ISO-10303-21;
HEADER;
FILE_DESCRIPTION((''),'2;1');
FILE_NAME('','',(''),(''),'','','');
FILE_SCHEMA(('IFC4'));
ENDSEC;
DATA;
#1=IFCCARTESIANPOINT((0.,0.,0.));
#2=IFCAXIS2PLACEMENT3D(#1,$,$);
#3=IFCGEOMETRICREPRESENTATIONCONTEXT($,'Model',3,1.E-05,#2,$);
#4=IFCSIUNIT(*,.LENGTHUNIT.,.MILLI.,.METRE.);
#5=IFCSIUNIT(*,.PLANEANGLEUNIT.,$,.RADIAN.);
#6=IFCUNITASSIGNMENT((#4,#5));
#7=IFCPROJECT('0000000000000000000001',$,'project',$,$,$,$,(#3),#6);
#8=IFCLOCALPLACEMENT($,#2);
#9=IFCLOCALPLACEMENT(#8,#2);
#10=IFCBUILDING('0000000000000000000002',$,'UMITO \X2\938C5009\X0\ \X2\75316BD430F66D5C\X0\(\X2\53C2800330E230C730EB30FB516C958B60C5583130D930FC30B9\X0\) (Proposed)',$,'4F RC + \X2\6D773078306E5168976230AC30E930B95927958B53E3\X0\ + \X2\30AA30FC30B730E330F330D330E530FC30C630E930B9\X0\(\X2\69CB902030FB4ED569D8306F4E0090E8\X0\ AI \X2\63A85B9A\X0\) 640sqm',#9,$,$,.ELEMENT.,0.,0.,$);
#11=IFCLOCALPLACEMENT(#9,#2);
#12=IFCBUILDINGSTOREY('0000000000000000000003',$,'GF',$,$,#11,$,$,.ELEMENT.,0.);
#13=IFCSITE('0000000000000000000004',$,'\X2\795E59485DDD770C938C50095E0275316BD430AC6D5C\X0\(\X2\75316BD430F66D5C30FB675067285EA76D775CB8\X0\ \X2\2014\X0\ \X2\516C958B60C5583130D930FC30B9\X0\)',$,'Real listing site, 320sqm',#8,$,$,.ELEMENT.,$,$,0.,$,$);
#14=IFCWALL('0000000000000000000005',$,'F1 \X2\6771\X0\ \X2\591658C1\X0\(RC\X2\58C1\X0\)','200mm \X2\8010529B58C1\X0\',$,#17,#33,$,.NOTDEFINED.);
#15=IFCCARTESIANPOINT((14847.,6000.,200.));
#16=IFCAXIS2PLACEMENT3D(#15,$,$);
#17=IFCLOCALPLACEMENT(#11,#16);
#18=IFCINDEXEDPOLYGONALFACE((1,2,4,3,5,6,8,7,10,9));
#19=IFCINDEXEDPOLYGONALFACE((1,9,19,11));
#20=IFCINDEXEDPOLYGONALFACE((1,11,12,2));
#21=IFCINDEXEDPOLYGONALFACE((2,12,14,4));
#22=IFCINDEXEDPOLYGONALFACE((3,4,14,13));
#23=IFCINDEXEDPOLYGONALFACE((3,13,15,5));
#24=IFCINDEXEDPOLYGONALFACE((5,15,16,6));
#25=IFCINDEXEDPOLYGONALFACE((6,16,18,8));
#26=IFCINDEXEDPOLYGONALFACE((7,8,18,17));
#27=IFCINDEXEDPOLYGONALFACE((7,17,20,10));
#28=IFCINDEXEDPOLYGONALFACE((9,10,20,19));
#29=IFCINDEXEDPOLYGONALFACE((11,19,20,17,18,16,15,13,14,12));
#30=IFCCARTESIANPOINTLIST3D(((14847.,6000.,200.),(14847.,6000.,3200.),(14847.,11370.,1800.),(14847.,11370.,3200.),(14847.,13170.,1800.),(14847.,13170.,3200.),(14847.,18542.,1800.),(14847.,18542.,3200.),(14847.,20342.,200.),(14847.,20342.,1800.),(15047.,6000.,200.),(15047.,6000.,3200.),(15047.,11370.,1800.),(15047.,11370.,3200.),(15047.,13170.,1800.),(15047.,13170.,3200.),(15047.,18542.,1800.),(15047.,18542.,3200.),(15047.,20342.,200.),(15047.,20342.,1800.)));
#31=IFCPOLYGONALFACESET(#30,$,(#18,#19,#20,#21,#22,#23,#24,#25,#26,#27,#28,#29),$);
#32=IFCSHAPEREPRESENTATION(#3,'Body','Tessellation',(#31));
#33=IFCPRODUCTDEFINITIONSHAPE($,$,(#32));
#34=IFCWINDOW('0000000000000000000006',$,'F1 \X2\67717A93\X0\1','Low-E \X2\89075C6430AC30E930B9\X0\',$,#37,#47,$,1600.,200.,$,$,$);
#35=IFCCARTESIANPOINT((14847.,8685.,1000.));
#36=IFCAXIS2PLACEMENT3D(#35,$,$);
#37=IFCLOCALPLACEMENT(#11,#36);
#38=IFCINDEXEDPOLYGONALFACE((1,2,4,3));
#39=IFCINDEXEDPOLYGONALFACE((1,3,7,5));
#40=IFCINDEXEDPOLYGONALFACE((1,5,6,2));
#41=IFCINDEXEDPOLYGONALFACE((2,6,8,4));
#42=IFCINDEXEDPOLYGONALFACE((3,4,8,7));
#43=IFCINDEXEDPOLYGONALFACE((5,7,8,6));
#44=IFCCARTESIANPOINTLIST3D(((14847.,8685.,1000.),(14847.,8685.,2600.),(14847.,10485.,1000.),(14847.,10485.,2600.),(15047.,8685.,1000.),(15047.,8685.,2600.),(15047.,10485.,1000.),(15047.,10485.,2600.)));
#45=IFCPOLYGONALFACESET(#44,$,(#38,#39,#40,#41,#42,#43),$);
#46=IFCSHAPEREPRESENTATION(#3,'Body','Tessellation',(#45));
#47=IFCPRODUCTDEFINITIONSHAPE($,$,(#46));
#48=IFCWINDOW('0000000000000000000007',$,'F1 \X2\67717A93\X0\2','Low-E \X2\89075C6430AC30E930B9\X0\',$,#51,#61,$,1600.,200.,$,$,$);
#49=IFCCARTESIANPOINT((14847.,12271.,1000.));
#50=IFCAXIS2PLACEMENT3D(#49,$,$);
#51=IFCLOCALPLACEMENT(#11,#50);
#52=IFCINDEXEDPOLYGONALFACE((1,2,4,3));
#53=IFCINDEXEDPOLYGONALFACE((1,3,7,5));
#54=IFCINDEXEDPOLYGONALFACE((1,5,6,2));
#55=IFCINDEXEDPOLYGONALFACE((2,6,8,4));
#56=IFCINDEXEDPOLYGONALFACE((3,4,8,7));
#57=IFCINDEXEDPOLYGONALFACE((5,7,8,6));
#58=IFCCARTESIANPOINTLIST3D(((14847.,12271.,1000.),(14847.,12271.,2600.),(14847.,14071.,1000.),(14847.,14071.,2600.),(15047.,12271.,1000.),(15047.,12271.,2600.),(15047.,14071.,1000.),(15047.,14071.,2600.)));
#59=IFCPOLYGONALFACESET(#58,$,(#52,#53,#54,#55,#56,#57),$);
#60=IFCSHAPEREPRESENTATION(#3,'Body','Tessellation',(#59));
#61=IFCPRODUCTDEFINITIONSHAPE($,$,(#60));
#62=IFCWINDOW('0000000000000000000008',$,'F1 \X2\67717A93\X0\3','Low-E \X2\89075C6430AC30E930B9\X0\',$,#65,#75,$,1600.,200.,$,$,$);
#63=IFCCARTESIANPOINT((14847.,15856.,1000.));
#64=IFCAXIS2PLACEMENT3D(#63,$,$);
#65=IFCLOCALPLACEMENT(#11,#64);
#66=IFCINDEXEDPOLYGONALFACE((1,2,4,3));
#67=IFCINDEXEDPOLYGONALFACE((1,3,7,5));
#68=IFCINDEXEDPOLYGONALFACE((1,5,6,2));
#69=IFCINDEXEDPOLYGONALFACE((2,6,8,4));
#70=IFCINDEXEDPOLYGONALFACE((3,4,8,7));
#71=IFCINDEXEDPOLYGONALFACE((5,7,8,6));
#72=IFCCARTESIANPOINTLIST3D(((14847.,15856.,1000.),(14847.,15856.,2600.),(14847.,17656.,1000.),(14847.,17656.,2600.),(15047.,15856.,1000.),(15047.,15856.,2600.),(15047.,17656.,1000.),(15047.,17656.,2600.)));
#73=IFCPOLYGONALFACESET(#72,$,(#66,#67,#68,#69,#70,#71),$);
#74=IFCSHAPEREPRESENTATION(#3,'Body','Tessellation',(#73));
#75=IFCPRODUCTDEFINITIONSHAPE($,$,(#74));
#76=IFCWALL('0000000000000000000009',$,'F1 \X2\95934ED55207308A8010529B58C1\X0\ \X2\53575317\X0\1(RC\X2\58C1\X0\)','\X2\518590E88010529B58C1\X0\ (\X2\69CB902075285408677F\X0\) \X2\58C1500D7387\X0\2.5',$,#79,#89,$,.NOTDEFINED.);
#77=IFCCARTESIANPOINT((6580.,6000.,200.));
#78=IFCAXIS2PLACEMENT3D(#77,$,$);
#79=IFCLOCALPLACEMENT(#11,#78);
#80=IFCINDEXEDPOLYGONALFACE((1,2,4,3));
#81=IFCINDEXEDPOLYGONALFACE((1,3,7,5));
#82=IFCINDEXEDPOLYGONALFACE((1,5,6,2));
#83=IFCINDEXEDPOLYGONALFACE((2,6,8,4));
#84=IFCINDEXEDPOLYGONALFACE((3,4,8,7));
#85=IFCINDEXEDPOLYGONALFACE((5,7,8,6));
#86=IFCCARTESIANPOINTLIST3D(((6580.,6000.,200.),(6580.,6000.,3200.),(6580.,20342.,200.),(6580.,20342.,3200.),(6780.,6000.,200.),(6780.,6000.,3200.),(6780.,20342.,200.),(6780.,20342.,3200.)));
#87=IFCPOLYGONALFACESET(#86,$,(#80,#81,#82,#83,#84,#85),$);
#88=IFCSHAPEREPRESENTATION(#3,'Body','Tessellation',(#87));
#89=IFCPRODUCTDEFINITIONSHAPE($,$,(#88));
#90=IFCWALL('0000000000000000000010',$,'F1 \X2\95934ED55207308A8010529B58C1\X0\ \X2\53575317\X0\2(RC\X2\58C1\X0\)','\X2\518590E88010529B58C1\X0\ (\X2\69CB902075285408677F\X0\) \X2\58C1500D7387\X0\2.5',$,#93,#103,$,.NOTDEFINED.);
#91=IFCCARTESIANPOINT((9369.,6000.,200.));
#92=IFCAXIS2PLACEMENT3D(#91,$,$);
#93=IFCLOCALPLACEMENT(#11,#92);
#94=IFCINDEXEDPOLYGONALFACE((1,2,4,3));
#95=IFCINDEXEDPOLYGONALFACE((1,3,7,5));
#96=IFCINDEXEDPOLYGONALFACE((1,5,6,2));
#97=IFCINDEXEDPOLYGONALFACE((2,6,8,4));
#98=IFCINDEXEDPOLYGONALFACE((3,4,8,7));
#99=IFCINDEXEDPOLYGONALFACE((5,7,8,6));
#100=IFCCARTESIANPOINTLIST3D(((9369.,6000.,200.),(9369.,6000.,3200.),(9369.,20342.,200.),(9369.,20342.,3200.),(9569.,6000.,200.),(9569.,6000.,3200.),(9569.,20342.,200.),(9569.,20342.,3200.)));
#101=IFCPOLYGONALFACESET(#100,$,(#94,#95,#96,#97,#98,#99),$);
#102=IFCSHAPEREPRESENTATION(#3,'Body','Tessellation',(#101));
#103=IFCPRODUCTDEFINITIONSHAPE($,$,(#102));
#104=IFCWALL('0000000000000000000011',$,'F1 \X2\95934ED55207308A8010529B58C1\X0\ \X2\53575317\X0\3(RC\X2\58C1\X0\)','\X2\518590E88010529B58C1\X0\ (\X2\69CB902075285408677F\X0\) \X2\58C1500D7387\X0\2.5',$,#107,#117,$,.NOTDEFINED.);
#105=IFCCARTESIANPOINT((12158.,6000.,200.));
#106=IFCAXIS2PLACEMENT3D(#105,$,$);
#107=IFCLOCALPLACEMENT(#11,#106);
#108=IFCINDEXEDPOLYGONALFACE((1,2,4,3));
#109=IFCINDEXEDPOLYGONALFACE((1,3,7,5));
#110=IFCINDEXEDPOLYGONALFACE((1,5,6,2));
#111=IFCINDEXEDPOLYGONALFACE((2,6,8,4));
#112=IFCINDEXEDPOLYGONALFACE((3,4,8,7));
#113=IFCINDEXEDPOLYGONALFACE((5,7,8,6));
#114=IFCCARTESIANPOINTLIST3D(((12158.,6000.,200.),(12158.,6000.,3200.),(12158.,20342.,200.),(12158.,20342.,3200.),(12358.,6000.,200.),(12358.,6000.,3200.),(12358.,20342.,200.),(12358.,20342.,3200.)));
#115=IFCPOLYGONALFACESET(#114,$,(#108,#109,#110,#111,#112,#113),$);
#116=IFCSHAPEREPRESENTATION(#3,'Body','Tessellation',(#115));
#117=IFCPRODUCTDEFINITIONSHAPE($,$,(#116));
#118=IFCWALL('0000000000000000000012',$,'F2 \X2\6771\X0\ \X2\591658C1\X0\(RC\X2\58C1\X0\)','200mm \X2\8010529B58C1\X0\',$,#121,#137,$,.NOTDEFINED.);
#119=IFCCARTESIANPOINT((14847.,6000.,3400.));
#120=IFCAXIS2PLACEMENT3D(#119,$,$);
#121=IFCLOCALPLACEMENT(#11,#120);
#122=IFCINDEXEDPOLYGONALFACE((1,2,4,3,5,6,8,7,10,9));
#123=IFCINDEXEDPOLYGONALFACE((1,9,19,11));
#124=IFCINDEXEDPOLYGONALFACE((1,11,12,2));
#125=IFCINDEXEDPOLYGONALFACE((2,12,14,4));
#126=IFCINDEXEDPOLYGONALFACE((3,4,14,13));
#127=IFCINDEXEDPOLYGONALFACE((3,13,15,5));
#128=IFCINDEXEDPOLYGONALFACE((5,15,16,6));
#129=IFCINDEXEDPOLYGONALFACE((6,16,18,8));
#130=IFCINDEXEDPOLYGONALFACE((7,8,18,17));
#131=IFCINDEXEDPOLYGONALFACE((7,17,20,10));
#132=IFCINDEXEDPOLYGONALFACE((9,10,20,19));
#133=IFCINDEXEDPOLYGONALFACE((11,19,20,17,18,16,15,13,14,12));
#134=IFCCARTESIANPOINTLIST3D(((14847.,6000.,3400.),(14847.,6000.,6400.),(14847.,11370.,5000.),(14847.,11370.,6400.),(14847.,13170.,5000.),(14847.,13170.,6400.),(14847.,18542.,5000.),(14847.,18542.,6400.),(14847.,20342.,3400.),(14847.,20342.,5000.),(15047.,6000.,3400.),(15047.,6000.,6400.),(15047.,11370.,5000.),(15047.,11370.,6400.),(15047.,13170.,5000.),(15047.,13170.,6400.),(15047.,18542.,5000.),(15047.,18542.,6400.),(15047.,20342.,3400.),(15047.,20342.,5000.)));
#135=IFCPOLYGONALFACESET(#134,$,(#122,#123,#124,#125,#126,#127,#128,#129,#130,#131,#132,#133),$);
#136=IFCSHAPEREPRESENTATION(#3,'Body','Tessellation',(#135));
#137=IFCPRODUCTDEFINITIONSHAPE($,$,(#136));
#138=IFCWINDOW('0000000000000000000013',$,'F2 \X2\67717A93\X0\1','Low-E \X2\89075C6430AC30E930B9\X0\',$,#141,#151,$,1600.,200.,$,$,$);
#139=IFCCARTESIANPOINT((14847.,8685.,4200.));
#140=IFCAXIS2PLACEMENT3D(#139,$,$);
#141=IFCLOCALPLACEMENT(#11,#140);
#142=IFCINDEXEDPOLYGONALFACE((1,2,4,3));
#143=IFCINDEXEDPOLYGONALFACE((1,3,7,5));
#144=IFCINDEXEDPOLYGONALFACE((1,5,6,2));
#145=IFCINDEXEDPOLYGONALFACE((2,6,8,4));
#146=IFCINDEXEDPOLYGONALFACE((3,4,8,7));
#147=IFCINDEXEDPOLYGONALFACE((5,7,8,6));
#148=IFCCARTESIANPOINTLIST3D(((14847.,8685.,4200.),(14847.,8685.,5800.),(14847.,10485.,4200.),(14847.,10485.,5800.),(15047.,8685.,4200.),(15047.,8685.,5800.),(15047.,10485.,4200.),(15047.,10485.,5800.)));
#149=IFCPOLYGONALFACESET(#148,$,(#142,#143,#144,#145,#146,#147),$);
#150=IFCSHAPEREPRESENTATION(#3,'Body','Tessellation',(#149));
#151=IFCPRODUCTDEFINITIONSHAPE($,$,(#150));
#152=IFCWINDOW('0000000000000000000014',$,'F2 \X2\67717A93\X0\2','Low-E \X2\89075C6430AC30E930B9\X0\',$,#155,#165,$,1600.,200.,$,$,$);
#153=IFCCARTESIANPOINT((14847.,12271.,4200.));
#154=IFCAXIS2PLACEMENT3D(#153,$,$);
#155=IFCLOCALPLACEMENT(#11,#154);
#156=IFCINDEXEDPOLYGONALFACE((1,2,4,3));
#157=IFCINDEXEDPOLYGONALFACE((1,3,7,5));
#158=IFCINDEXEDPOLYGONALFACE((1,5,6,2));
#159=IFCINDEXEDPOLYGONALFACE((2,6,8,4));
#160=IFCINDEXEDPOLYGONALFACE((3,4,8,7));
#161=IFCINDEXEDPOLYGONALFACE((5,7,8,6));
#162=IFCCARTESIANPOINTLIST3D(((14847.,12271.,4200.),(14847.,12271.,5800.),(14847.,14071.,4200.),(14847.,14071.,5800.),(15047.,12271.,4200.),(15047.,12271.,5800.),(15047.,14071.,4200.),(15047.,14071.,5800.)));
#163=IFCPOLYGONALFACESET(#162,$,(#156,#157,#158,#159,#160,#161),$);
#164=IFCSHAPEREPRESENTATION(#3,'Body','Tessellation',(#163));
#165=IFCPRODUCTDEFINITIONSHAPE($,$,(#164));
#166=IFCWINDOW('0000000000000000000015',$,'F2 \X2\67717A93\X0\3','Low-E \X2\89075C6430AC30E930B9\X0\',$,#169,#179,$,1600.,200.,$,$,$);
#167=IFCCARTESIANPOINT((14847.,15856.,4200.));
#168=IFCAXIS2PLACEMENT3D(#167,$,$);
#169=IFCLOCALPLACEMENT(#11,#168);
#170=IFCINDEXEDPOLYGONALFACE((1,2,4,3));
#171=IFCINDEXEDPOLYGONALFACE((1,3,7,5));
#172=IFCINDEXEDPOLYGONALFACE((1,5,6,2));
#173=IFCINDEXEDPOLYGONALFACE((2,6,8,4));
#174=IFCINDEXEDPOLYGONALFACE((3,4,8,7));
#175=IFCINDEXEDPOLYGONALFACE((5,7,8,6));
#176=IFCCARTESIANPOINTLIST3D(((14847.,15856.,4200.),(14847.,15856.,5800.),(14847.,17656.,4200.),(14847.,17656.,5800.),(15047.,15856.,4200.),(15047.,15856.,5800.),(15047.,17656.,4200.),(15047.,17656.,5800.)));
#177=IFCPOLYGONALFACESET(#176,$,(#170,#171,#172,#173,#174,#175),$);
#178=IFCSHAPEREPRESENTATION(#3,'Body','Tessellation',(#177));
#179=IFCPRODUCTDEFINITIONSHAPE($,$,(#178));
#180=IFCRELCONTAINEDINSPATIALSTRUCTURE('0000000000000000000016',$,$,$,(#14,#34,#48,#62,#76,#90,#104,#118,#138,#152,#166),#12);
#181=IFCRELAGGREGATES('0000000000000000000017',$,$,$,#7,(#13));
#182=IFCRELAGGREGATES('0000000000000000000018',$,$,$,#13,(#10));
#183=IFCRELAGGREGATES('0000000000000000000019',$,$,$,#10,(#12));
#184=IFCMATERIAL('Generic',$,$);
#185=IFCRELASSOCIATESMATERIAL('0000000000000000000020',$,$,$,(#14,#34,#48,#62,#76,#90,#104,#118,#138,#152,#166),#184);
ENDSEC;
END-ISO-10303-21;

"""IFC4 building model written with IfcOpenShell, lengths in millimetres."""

from ifc_helpers import new_model, si_unit, frame, frame_2d, origin, place, context, project, spatial, rectangle, extrude, material, element, fill, save


model = new_model("IFC4")

# Units and contexts
model_context = context("Model", 3, precision=1e-05, world=origin())
ifc_project = project(units=[si_unit("LENGTHUNIT", "METRE", prefix="MILLI"), si_unit("PLANEANGLEUNIT", "RADIAN")], contexts=[model_context])

# Site, building, storey
site_placement = place(None, origin())
site = spatial("IfcSite", under=ifc_project, at=site_placement, Name="神奈川県鎌倉市由比ガ浜(由比ヶ浜・材木座海岸 — 公開情報ベース)", ObjectType="Real listing site, 320sqm", CompositionType="ELEMENT", RefElevation=0.0)
building_placement = place(site_placement, origin())
building = spatial("IfcBuilding", under=site, at=building_placement, Name="UMITO 鎌倉 由比ヶ浜(参考モデル・公開情報ベース) (Proposed)", ObjectType="4F RC + 海への全面ガラス大開口 + オーシャンビューテラス(構造・仕様は一部 AI 推定) 640sqm", CompositionType="ELEMENT", ElevationOfRefHeight=0.0, ElevationOfTerrain=0.0)
storey_placement = place(building_placement, origin())
storey = spatial("IfcBuildingStorey", under=building, at=storey_placement, Name="GF", CompositionType="ELEMENT", Elevation=0.0)

# Wall, openings, windows
ifc_material = material(Name="Generic")
wall_1_placement = place(storey_placement, frame((14847.0, 6000.0, 200.0)))
wall_1 = element("IfcWall", 1, at=wall_1_placement, inside=storey, material=ifc_material, Name="F1 東 外壁(RC壁)", Description="200mm 耐力壁", PredefinedType="NOTDEFINED", context=model_context, shape_type="SweptSolid", body=[
    extrude(rectangle(XDim=200.0, YDim=14342.0, at=frame_2d((100.0, 7171.0))), frame((14847.0, 6000.0, 200.0)), (0.0, 0.0, 1.0), 3000.0),
])
opening_1_placement = place(storey_placement, frame((14847.0, 8685.0, 1000.0)))
opening_1 = element("IfcOpeningElement", 2, at=opening_1_placement, cuts=wall_1, PredefinedType="NOTDEFINED", context=model_context, shape_type="SweptSolid", body=[
    extrude(rectangle(XDim=200.0, YDim=1800.0, at=frame_2d((100.0, 900.0))), frame((14847.0, 8685.0, 1000.0)), (0.0, 0.0, 1.0), 1600.0),
])
opening_2_placement = place(storey_placement, frame((14847.0, 12271.0, 1000.0)))
opening_2 = element("IfcOpeningElement", 3, at=opening_2_placement, cuts=wall_1, PredefinedType="NOTDEFINED", context=model_context, shape_type="SweptSolid", body=[
    extrude(rectangle(XDim=200.0, YDim=1800.0, at=frame_2d((100.0, 900.0))), frame((14847.0, 12271.0, 1000.0)), (0.0, 0.0, 1.0), 1600.0),
])
opening_3_placement = place(storey_placement, frame((14847.0, 15856.0, 1000.0)))
opening_3 = element("IfcOpeningElement", 4, at=opening_3_placement, cuts=wall_1, PredefinedType="NOTDEFINED", context=model_context, shape_type="SweptSolid", body=[
    extrude(rectangle(XDim=200.0, YDim=1800.0, at=frame_2d((100.0, 900.0))), frame((14847.0, 15856.0, 1000.0)), (0.0, 0.0, 1.0), 1600.0),
])
window_1_placement = place(storey_placement, frame((14847.0, 8685.0, 1000.0)))
window_1 = element("IfcWindow", 5, at=window_1_placement, inside=storey, material=ifc_material, Name="F1 東窓1", Description="Low-E 複層ガラス", OverallHeight=1600.0, OverallWidth=200.0, context=model_context, shape_type="SweptSolid", body=[
    extrude(rectangle(XDim=200.0, YDim=1800.0, at=frame_2d((100.0, 900.0))), frame((14847.0, 8685.0, 1000.0)), (0.0, 0.0, 1.0), 1600.0),
])
fill(opening_1, window_1)
window_2_placement = place(storey_placement, frame((14847.0, 12271.0, 1000.0)))
window_2 = element("IfcWindow", 6, at=window_2_placement, inside=storey, material=ifc_material, Name="F1 東窓2", Description="Low-E 複層ガラス", OverallHeight=1600.0, OverallWidth=200.0, context=model_context, shape_type="SweptSolid", body=[
    extrude(rectangle(XDim=200.0, YDim=1800.0, at=frame_2d((100.0, 900.0))), frame((14847.0, 12271.0, 1000.0)), (0.0, 0.0, 1.0), 1600.0),
])
fill(opening_2, window_2)
window_3_placement = place(storey_placement, frame((14847.0, 15856.0, 1000.0)))
window_3 = element("IfcWindow", 7, at=window_3_placement, inside=storey, material=ifc_material, Name="F1 東窓3", Description="Low-E 複層ガラス", OverallHeight=1600.0, OverallWidth=200.0, context=model_context, shape_type="SweptSolid", body=[
    extrude(rectangle(XDim=200.0, YDim=1800.0, at=frame_2d((100.0, 900.0))), frame((14847.0, 15856.0, 1000.0)), (0.0, 0.0, 1.0), 1600.0),
])
fill(opening_3, window_3)

# Walls
wall_2_placement = place(storey_placement, frame((6580.0, 6000.0, 200.0)))
element("IfcWall", 8, at=wall_2_placement, inside=storey, material=ifc_material, Name="F1 間仕切り耐力壁 南北1(RC壁)", Description="内部耐力壁 (構造用合板) 壁倍率2.5", PredefinedType="NOTDEFINED", context=model_context, shape_type="SweptSolid", body=[
    extrude(rectangle(XDim=200.0, YDim=14342.0, at=frame_2d((100.0, 7171.0))), frame((6580.0, 6000.0, 200.0)), (0.0, 0.0, 1.0), 3000.0),
])
wall_3_placement = place(storey_placement, frame((9369.0, 6000.0, 200.0)))
element("IfcWall", 9, at=wall_3_placement, inside=storey, material=ifc_material, Name="F1 間仕切り耐力壁 南北2(RC壁)", Description="内部耐力壁 (構造用合板) 壁倍率2.5", PredefinedType="NOTDEFINED", context=model_context, shape_type="SweptSolid", body=[
    extrude(rectangle(XDim=200.0, YDim=14342.0, at=frame_2d((100.0, 7171.0))), frame((9369.0, 6000.0, 200.0)), (0.0, 0.0, 1.0), 3000.0),
])
wall_4_placement = place(storey_placement, frame((12158.0, 6000.0, 200.0)))
element("IfcWall", 10, at=wall_4_placement, inside=storey, material=ifc_material, Name="F1 間仕切り耐力壁 南北3(RC壁)", Description="内部耐力壁 (構造用合板) 壁倍率2.5", PredefinedType="NOTDEFINED", context=model_context, shape_type="SweptSolid", body=[
    extrude(rectangle(XDim=200.0, YDim=14342.0, at=frame_2d((100.0, 7171.0))), frame((12158.0, 6000.0, 200.0)), (0.0, 0.0, 1.0), 3000.0),
])

# Wall, openings, windows
wall_5_placement = place(storey_placement, frame((14847.0, 6000.0, 3400.0)))
wall_5 = element("IfcWall", 11, at=wall_5_placement, inside=storey, material=ifc_material, Name="F2 東 外壁(RC壁)", Description="200mm 耐力壁", PredefinedType="NOTDEFINED", context=model_context, shape_type="SweptSolid", body=[
    extrude(rectangle(XDim=200.0, YDim=14342.0, at=frame_2d((100.0, 7171.0))), frame((14847.0, 6000.0, 3400.0)), (0.0, 0.0, 1.0), 3000.0),
])
opening_4_placement = place(storey_placement, frame((14847.0, 8685.0, 4200.0)))
opening_4 = element("IfcOpeningElement", 12, at=opening_4_placement, cuts=wall_5, PredefinedType="NOTDEFINED", context=model_context, shape_type="SweptSolid", body=[
    extrude(rectangle(XDim=200.0, YDim=1800.0, at=frame_2d((100.0, 900.0))), frame((14847.0, 8685.0, 4200.0)), (0.0, 0.0, 1.0), 1600.0),
])
opening_5_placement = place(storey_placement, frame((14847.0, 12271.0, 4200.0)))
opening_5 = element("IfcOpeningElement", 13, at=opening_5_placement, cuts=wall_5, PredefinedType="NOTDEFINED", context=model_context, shape_type="SweptSolid", body=[
    extrude(rectangle(XDim=200.0, YDim=1800.0, at=frame_2d((100.0, 900.0))), frame((14847.0, 12271.0, 4200.0)), (0.0, 0.0, 1.0), 1600.0),
])
opening_6_placement = place(storey_placement, frame((14847.0, 15856.0, 4200.0)))
opening_6 = element("IfcOpeningElement", 14, at=opening_6_placement, cuts=wall_5, PredefinedType="NOTDEFINED", context=model_context, shape_type="SweptSolid", body=[
    extrude(rectangle(XDim=200.0, YDim=1800.0, at=frame_2d((100.0, 900.0))), frame((14847.0, 15856.0, 4200.0)), (0.0, 0.0, 1.0), 1600.0),
])
window_4_placement = place(storey_placement, frame((14847.0, 8685.0, 4200.0)))
window_4 = element("IfcWindow", 15, at=window_4_placement, inside=storey, material=ifc_material, Name="F2 東窓1", Description="Low-E 複層ガラス", OverallHeight=1600.0, OverallWidth=200.0, context=model_context, shape_type="SweptSolid", body=[
    extrude(rectangle(XDim=200.0, YDim=1800.0, at=frame_2d((100.0, 900.0))), frame((14847.0, 8685.0, 4200.0)), (0.0, 0.0, 1.0), 1600.0),
])
fill(opening_4, window_4)
window_5_placement = place(storey_placement, frame((14847.0, 12271.0, 4200.0)))
window_5 = element("IfcWindow", 16, at=window_5_placement, inside=storey, material=ifc_material, Name="F2 東窓2", Description="Low-E 複層ガラス", OverallHeight=1600.0, OverallWidth=200.0, context=model_context, shape_type="SweptSolid", body=[
    extrude(rectangle(XDim=200.0, YDim=1800.0, at=frame_2d((100.0, 900.0))), frame((14847.0, 12271.0, 4200.0)), (0.0, 0.0, 1.0), 1600.0),
])
fill(opening_5, window_5)
window_6_placement = place(storey_placement, frame((14847.0, 15856.0, 4200.0)))
window_6 = element("IfcWindow", 17, at=window_6_placement, inside=storey, material=ifc_material, Name="F2 東窓3", Description="Low-E 複層ガラス", OverallHeight=1600.0, OverallWidth=200.0, context=model_context, shape_type="SweptSolid", body=[
    extrude(rectangle(XDim=200.0, YDim=1800.0, at=frame_2d((100.0, 900.0))), frame((14847.0, 15856.0, 4200.0)), (0.0, 0.0, 1.0), 1600.0),
])
fill(opening_6, window_6)

save(model, "model.ifc")
